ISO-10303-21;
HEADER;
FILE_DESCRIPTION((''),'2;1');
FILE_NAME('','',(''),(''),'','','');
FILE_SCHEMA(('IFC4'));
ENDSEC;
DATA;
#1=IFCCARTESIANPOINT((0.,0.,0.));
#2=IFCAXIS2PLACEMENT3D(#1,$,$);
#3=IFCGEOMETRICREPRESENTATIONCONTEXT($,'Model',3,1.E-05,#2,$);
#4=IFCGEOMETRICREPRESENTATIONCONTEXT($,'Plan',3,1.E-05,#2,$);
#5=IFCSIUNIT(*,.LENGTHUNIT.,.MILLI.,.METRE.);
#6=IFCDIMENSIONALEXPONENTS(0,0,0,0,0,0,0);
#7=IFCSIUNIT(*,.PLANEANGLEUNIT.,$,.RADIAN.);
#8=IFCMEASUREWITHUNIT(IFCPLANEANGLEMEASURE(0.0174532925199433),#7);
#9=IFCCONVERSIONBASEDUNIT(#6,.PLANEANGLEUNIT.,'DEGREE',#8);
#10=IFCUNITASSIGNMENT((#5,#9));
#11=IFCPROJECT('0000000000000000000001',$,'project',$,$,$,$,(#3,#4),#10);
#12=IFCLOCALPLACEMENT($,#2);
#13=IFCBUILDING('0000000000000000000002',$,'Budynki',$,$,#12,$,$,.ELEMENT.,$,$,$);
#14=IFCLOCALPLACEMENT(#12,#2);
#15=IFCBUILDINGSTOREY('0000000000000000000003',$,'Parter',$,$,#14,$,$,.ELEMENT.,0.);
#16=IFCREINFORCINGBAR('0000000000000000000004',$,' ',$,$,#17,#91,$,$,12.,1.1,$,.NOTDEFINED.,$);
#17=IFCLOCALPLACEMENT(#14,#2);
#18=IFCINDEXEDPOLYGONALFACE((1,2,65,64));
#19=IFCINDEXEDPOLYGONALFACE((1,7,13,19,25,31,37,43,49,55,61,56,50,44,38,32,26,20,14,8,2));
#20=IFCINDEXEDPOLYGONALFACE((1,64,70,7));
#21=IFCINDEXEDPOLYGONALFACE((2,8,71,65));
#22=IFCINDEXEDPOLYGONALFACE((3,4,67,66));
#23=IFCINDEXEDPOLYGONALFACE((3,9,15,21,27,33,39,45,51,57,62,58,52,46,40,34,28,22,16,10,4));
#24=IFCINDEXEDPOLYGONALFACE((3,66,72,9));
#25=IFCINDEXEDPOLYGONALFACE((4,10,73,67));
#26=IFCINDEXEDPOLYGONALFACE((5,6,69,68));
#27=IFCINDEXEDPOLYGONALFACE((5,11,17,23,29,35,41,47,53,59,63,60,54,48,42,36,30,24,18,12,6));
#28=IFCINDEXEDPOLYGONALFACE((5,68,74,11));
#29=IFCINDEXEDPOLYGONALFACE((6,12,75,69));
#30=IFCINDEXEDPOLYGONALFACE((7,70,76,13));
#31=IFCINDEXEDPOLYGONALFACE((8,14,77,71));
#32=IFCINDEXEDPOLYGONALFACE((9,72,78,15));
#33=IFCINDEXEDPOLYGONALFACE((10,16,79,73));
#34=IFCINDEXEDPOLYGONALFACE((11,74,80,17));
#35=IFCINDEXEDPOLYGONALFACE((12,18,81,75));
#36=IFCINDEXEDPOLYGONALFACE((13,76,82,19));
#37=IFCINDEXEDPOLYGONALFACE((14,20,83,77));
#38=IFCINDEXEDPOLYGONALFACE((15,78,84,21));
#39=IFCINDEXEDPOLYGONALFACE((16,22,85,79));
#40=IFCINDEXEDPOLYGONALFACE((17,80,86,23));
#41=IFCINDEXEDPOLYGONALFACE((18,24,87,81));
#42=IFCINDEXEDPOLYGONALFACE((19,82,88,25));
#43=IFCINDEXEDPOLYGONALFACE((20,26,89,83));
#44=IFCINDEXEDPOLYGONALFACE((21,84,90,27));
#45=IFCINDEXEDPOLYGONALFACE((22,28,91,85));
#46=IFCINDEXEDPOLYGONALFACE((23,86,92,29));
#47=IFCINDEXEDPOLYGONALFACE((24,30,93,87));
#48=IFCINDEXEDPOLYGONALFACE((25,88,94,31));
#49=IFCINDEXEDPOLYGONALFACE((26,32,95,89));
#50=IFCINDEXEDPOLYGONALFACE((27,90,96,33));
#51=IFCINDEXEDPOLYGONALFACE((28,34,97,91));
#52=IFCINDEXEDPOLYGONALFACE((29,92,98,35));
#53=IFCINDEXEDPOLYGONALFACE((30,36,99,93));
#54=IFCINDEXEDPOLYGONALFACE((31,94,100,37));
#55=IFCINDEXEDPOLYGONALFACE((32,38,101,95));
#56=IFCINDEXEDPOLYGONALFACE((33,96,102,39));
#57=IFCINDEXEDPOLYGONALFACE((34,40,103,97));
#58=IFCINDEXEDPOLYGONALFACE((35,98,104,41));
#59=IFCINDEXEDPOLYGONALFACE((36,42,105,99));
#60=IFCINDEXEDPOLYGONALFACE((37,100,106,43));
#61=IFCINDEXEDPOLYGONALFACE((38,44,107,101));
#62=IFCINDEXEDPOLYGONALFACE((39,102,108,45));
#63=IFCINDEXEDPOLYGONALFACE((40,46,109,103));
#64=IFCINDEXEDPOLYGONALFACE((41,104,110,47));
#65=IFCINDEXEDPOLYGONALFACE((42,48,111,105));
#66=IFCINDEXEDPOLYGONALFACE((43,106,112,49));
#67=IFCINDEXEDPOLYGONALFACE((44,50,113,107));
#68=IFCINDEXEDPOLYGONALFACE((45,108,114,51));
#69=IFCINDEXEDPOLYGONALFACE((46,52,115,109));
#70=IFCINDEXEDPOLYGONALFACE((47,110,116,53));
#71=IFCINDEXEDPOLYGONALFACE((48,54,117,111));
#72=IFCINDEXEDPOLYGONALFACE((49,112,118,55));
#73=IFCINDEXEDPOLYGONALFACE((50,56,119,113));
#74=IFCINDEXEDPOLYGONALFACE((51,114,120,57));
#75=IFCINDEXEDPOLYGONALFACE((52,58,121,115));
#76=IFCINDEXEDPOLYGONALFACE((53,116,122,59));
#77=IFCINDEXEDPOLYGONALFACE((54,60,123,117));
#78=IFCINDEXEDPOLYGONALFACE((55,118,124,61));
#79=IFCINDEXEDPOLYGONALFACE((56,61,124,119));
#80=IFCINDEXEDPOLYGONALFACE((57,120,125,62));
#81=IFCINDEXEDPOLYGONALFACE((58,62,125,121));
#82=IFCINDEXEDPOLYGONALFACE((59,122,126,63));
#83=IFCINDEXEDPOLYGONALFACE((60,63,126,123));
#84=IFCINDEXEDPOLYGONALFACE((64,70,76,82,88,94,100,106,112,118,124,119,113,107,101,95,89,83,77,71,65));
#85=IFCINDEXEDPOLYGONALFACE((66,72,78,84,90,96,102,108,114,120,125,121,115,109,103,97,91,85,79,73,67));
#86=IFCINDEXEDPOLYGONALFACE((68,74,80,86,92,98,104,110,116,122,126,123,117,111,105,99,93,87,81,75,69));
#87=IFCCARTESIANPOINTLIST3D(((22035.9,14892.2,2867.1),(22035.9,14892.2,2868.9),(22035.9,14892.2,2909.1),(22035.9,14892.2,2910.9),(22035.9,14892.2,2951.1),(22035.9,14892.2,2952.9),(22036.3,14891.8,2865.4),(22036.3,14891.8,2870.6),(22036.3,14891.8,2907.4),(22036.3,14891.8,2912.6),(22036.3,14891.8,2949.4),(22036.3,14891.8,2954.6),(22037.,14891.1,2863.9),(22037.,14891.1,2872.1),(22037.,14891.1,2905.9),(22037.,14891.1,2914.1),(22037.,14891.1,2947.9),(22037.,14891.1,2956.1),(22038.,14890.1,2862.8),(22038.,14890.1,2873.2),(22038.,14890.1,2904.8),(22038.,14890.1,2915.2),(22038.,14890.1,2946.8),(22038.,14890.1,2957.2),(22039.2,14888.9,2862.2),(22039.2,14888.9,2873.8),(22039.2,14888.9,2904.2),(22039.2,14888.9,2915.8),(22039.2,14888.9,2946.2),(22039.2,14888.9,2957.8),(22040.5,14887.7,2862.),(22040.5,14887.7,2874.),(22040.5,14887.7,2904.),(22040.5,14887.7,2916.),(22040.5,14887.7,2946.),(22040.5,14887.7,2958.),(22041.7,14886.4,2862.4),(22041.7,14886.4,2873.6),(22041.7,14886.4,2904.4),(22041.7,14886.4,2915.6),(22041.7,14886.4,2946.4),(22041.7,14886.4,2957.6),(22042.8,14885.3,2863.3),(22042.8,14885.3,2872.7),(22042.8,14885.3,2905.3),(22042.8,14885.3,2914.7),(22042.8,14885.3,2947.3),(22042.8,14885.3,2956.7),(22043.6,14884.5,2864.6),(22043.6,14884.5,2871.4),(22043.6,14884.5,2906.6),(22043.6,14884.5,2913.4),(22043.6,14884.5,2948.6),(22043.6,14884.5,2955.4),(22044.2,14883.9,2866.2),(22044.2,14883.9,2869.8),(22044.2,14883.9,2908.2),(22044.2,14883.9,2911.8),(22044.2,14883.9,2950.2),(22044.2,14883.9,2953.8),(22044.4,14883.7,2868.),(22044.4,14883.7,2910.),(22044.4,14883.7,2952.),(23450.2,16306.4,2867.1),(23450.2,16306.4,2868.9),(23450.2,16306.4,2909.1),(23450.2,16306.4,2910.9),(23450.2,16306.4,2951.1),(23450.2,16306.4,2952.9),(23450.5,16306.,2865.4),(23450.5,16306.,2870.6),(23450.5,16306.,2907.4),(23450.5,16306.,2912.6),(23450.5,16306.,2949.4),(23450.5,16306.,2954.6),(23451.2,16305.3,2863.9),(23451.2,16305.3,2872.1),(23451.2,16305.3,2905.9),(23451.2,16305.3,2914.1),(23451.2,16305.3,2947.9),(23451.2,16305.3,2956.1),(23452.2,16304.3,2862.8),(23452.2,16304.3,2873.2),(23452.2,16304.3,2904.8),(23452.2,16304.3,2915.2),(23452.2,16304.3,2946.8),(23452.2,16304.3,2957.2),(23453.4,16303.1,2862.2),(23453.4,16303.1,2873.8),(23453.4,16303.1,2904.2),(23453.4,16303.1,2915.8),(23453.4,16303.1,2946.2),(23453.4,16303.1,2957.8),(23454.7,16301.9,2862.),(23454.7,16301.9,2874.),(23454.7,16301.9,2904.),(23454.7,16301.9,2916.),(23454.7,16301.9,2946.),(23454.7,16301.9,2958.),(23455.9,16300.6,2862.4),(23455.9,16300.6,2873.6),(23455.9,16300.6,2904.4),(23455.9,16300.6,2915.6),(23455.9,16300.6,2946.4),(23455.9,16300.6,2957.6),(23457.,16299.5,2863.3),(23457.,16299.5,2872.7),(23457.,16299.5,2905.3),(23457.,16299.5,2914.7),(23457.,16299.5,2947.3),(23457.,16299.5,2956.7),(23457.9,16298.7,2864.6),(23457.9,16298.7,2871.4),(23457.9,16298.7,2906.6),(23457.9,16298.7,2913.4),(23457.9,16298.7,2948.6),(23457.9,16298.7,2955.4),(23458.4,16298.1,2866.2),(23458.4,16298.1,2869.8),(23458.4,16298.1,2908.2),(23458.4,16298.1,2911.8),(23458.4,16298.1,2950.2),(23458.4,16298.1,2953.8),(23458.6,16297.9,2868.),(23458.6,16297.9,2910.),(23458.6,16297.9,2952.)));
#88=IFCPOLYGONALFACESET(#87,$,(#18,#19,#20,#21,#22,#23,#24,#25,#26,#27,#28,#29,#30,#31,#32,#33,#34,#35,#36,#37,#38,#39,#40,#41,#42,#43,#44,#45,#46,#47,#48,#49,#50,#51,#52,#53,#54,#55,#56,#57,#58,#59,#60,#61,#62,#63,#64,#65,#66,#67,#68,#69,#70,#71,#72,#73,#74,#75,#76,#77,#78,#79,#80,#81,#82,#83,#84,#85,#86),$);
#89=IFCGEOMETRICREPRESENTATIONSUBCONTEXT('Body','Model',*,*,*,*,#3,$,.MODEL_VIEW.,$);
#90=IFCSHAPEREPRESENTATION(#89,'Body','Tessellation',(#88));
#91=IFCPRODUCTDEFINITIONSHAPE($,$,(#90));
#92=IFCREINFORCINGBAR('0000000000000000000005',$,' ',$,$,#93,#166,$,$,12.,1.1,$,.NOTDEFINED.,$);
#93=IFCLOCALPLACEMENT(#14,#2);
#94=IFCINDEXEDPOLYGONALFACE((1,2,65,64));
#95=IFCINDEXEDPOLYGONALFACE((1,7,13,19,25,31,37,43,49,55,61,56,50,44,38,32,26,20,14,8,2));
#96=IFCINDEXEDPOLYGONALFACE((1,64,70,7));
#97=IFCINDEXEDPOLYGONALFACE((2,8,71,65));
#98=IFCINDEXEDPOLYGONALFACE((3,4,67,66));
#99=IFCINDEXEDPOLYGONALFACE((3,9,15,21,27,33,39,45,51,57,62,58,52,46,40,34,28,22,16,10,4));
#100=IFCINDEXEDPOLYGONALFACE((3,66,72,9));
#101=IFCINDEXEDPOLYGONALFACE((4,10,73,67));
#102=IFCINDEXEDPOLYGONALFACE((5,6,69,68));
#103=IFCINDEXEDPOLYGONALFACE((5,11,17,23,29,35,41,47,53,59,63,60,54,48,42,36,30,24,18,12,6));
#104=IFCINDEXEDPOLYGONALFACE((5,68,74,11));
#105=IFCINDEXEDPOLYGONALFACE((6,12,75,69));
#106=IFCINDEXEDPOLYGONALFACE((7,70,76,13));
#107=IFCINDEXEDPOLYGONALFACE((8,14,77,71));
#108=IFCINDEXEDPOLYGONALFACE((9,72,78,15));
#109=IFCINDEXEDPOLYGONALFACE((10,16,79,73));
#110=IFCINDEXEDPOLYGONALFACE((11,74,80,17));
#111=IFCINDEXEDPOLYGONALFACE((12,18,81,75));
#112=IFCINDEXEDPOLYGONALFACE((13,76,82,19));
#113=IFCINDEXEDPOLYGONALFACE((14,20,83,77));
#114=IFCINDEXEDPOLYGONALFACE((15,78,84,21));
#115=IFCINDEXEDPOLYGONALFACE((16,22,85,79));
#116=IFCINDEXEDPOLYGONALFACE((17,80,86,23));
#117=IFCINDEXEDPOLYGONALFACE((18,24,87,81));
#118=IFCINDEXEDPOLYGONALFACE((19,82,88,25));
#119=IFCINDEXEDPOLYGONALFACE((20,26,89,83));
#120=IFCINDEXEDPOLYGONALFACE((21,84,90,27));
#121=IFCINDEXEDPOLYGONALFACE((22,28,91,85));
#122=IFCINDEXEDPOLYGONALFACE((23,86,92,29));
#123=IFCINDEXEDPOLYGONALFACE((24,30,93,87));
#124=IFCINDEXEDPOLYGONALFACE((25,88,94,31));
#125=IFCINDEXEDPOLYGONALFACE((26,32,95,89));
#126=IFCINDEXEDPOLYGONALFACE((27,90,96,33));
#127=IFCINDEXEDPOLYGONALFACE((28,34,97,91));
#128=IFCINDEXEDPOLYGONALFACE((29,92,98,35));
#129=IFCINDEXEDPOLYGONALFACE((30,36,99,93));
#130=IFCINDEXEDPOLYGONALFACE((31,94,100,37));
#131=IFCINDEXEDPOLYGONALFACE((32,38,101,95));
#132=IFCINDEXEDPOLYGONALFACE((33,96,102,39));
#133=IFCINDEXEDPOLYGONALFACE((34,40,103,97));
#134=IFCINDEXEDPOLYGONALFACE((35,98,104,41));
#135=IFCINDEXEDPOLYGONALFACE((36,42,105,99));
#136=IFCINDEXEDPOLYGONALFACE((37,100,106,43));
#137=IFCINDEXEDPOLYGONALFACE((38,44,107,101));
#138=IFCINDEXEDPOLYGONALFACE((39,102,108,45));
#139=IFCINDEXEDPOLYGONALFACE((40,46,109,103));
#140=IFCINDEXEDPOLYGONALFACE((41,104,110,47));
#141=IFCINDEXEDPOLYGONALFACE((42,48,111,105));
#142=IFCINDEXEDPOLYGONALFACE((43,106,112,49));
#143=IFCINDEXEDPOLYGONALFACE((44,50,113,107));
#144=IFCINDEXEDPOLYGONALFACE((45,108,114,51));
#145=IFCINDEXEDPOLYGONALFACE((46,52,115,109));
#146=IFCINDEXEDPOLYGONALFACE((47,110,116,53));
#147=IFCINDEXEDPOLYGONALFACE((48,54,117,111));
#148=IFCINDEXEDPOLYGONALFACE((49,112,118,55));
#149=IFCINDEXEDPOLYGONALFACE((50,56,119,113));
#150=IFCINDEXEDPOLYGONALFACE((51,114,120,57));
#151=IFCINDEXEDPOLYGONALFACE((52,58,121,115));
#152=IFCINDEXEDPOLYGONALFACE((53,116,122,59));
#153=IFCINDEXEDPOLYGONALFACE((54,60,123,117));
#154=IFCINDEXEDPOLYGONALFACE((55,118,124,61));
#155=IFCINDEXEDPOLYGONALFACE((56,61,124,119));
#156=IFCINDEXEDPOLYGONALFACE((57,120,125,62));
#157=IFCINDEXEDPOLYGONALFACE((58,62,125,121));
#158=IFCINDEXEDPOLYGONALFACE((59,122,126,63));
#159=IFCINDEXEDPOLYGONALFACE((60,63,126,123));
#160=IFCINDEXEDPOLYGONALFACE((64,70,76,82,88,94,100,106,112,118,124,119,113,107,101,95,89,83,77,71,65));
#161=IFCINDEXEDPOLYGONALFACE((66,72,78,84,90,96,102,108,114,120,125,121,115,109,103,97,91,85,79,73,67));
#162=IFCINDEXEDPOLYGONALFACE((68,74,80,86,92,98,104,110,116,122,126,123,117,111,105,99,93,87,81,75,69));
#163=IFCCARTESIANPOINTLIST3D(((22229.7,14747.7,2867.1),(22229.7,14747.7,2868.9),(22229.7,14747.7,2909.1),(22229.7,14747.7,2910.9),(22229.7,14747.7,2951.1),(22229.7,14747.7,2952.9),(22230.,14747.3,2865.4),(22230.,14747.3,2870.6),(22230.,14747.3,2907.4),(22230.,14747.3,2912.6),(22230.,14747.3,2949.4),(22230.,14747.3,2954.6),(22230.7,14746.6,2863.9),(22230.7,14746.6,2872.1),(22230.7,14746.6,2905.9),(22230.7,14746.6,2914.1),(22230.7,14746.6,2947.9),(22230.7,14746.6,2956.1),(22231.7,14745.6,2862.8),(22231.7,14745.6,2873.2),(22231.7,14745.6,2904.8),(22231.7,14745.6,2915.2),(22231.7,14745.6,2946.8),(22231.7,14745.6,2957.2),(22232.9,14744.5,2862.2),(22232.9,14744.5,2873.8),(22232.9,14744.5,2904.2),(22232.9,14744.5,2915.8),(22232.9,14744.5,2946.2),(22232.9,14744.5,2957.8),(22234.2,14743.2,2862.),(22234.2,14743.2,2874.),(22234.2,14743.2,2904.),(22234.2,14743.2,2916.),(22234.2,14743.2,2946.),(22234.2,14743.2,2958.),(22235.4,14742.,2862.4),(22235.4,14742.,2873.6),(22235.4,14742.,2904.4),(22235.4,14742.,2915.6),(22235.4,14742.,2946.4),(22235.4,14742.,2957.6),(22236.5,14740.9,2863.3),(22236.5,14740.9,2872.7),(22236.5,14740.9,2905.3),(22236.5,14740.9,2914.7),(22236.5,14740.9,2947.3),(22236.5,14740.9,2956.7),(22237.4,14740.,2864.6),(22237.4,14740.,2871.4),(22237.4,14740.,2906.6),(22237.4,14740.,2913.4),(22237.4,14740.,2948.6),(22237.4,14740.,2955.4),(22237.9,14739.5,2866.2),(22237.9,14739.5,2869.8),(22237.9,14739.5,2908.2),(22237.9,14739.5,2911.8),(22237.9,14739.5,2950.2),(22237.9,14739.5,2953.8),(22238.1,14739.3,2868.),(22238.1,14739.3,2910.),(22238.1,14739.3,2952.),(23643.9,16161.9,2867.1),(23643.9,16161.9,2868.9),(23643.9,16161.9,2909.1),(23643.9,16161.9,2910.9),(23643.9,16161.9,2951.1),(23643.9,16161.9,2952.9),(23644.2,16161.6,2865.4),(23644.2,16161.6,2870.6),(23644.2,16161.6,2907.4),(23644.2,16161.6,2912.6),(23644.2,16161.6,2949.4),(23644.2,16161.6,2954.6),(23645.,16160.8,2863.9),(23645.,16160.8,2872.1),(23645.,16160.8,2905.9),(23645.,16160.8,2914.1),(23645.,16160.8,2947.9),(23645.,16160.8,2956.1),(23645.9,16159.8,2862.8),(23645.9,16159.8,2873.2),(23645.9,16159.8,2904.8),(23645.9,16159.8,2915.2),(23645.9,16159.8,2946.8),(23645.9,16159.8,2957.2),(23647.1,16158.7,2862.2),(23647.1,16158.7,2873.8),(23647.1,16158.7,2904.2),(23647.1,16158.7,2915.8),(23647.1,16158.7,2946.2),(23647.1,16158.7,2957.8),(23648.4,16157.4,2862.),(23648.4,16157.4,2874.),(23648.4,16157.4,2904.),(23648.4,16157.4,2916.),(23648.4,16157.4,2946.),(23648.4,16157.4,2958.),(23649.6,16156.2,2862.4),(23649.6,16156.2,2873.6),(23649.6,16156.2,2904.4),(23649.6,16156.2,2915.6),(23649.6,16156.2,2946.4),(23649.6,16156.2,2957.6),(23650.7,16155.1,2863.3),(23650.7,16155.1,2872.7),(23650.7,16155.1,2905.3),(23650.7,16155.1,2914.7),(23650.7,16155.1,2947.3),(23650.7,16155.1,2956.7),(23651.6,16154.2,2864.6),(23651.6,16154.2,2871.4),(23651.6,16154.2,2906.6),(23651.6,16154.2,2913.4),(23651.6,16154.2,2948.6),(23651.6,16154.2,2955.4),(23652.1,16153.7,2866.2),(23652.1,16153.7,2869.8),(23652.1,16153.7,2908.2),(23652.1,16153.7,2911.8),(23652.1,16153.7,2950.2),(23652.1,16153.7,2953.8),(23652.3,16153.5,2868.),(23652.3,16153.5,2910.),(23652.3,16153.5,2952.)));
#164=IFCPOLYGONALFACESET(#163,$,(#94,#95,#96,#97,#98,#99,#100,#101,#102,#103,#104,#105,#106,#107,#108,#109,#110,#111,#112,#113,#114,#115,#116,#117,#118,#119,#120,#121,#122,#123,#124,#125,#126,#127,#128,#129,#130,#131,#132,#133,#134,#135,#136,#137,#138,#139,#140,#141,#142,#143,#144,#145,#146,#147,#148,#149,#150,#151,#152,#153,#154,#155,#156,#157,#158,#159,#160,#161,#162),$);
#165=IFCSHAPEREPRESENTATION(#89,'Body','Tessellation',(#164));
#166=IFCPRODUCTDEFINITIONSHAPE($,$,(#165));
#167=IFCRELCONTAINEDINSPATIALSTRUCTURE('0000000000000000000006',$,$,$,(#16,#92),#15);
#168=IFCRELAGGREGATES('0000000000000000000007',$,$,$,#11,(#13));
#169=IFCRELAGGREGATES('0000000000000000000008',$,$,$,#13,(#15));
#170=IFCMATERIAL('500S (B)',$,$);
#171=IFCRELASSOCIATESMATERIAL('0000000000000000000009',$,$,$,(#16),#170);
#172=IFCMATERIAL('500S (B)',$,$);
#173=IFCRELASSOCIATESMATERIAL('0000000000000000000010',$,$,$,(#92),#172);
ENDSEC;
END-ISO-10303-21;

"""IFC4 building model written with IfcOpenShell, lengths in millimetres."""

from ifc_helpers import new_model, entity, si_unit, converted_unit, frame, origin, origin_with_axes, place, context, subcontext, project, spatial, source, transform, mapped, material, element, save


model = new_model("IFC4")

# Units and contexts
model_context = context("Model", 3, precision=1e-05, world=origin())
plan_context = context("Plan", 3, precision=1e-05, world=origin())
body_context = subcontext(model_context, "Body", "Model", "MODEL_VIEW")
ifc_project = project(units=[si_unit("LENGTHUNIT", "METRE", prefix="MILLI"), converted_unit("PLANEANGLEUNIT", "DEGREE", entity("IfcPlaneAngleMeasure", 0.0174532925199433), si_unit("PLANEANGLEUNIT", "RADIAN"), dimensions=[0, 0, 0, 0, 0, 0, 0])], contexts=[model_context, plan_context])

# Building, storey
building_placement = place(None, origin())
building = spatial("IfcBuilding", under=ifc_project, at=building_placement, Name="Budynki", CompositionType="ELEMENT")
storey_placement = place(building_placement, origin())
storey = spatial("IfcBuildingStorey", under=building, at=storey_placement, Name="Parter", CompositionType="ELEMENT", Elevation=0.0)

# Reinforcing bars
ifc_material_1 = material(Name="500S (B)")
shared_shape_1 = source(origin_with_axes(), body_context, "Body", "AdvancedSweptSolid", [
    entity("IfcSweptDiskSolid", entity("IfcPolyline", [entity("IfcCartesianPoint", [0.0, 0.0, 0.0]), entity("IfcCartesianPoint", [-1414.2, -1414.2, 0.0])]), 6.0, None, 0.0, 1.0),
])
reinforcing_bar_1_placement = place(storey_placement, frame((23454.3, 16302.2, 2868.0)))
element("IfcReinforcingBar", 1, at=reinforcing_bar_1_placement, inside=storey, material=ifc_material_1, Name=" ", CrossSectionArea=1.1, NominalDiameter=12.0, PredefinedType="NOTDEFINED", context=body_context, shape_type="MappedRepresentation", body=[
    mapped(shared_shape_1, transform((0.0, 0.0, 0.0), y_axis=(0.0, 1.0, 0.0), scale=1.0)),
    mapped(shared_shape_1, transform((0.0, 0.0, 42.0), y_axis=(0.0, 1.0, 0.0), scale=1.0)),
    mapped(shared_shape_1, transform((0.0, 0.0, 84.0), y_axis=(0.0, 1.0, 0.0), scale=1.0)),
])
ifc_material_2 = material(Name="500S (B)")
shared_shape_2 = source(origin_with_axes(), body_context, "Body", "AdvancedSweptSolid", [
    entity("IfcSweptDiskSolid", entity("IfcPolyline", [entity("IfcCartesianPoint", [0.0, 0.0, 0.0]), entity("IfcCartesianPoint", [-1414.2, -1414.2, 0.0])]), 6.0, None, 0.0, 1.0),
])
reinforcing_bar_2_placement = place(storey_placement, frame((23648.1, 16157.7, 2868.0)))
element("IfcReinforcingBar", 2, at=reinforcing_bar_2_placement, inside=storey, material=ifc_material_2, Name=" ", CrossSectionArea=1.1, NominalDiameter=12.0, PredefinedType="NOTDEFINED", context=body_context, shape_type="MappedRepresentation", body=[
    mapped(shared_shape_2, transform((0.0, 0.0, 0.0), y_axis=(0.0, 1.0, 0.0), scale=1.0)),
    mapped(shared_shape_2, transform((0.0, 0.0, 42.0), y_axis=(0.0, 1.0, 0.0), scale=1.0)),
    mapped(shared_shape_2, transform((0.0, 0.0, 84.0), y_axis=(0.0, 1.0, 0.0), scale=1.0)),
])

save(model, "model.ifc")
